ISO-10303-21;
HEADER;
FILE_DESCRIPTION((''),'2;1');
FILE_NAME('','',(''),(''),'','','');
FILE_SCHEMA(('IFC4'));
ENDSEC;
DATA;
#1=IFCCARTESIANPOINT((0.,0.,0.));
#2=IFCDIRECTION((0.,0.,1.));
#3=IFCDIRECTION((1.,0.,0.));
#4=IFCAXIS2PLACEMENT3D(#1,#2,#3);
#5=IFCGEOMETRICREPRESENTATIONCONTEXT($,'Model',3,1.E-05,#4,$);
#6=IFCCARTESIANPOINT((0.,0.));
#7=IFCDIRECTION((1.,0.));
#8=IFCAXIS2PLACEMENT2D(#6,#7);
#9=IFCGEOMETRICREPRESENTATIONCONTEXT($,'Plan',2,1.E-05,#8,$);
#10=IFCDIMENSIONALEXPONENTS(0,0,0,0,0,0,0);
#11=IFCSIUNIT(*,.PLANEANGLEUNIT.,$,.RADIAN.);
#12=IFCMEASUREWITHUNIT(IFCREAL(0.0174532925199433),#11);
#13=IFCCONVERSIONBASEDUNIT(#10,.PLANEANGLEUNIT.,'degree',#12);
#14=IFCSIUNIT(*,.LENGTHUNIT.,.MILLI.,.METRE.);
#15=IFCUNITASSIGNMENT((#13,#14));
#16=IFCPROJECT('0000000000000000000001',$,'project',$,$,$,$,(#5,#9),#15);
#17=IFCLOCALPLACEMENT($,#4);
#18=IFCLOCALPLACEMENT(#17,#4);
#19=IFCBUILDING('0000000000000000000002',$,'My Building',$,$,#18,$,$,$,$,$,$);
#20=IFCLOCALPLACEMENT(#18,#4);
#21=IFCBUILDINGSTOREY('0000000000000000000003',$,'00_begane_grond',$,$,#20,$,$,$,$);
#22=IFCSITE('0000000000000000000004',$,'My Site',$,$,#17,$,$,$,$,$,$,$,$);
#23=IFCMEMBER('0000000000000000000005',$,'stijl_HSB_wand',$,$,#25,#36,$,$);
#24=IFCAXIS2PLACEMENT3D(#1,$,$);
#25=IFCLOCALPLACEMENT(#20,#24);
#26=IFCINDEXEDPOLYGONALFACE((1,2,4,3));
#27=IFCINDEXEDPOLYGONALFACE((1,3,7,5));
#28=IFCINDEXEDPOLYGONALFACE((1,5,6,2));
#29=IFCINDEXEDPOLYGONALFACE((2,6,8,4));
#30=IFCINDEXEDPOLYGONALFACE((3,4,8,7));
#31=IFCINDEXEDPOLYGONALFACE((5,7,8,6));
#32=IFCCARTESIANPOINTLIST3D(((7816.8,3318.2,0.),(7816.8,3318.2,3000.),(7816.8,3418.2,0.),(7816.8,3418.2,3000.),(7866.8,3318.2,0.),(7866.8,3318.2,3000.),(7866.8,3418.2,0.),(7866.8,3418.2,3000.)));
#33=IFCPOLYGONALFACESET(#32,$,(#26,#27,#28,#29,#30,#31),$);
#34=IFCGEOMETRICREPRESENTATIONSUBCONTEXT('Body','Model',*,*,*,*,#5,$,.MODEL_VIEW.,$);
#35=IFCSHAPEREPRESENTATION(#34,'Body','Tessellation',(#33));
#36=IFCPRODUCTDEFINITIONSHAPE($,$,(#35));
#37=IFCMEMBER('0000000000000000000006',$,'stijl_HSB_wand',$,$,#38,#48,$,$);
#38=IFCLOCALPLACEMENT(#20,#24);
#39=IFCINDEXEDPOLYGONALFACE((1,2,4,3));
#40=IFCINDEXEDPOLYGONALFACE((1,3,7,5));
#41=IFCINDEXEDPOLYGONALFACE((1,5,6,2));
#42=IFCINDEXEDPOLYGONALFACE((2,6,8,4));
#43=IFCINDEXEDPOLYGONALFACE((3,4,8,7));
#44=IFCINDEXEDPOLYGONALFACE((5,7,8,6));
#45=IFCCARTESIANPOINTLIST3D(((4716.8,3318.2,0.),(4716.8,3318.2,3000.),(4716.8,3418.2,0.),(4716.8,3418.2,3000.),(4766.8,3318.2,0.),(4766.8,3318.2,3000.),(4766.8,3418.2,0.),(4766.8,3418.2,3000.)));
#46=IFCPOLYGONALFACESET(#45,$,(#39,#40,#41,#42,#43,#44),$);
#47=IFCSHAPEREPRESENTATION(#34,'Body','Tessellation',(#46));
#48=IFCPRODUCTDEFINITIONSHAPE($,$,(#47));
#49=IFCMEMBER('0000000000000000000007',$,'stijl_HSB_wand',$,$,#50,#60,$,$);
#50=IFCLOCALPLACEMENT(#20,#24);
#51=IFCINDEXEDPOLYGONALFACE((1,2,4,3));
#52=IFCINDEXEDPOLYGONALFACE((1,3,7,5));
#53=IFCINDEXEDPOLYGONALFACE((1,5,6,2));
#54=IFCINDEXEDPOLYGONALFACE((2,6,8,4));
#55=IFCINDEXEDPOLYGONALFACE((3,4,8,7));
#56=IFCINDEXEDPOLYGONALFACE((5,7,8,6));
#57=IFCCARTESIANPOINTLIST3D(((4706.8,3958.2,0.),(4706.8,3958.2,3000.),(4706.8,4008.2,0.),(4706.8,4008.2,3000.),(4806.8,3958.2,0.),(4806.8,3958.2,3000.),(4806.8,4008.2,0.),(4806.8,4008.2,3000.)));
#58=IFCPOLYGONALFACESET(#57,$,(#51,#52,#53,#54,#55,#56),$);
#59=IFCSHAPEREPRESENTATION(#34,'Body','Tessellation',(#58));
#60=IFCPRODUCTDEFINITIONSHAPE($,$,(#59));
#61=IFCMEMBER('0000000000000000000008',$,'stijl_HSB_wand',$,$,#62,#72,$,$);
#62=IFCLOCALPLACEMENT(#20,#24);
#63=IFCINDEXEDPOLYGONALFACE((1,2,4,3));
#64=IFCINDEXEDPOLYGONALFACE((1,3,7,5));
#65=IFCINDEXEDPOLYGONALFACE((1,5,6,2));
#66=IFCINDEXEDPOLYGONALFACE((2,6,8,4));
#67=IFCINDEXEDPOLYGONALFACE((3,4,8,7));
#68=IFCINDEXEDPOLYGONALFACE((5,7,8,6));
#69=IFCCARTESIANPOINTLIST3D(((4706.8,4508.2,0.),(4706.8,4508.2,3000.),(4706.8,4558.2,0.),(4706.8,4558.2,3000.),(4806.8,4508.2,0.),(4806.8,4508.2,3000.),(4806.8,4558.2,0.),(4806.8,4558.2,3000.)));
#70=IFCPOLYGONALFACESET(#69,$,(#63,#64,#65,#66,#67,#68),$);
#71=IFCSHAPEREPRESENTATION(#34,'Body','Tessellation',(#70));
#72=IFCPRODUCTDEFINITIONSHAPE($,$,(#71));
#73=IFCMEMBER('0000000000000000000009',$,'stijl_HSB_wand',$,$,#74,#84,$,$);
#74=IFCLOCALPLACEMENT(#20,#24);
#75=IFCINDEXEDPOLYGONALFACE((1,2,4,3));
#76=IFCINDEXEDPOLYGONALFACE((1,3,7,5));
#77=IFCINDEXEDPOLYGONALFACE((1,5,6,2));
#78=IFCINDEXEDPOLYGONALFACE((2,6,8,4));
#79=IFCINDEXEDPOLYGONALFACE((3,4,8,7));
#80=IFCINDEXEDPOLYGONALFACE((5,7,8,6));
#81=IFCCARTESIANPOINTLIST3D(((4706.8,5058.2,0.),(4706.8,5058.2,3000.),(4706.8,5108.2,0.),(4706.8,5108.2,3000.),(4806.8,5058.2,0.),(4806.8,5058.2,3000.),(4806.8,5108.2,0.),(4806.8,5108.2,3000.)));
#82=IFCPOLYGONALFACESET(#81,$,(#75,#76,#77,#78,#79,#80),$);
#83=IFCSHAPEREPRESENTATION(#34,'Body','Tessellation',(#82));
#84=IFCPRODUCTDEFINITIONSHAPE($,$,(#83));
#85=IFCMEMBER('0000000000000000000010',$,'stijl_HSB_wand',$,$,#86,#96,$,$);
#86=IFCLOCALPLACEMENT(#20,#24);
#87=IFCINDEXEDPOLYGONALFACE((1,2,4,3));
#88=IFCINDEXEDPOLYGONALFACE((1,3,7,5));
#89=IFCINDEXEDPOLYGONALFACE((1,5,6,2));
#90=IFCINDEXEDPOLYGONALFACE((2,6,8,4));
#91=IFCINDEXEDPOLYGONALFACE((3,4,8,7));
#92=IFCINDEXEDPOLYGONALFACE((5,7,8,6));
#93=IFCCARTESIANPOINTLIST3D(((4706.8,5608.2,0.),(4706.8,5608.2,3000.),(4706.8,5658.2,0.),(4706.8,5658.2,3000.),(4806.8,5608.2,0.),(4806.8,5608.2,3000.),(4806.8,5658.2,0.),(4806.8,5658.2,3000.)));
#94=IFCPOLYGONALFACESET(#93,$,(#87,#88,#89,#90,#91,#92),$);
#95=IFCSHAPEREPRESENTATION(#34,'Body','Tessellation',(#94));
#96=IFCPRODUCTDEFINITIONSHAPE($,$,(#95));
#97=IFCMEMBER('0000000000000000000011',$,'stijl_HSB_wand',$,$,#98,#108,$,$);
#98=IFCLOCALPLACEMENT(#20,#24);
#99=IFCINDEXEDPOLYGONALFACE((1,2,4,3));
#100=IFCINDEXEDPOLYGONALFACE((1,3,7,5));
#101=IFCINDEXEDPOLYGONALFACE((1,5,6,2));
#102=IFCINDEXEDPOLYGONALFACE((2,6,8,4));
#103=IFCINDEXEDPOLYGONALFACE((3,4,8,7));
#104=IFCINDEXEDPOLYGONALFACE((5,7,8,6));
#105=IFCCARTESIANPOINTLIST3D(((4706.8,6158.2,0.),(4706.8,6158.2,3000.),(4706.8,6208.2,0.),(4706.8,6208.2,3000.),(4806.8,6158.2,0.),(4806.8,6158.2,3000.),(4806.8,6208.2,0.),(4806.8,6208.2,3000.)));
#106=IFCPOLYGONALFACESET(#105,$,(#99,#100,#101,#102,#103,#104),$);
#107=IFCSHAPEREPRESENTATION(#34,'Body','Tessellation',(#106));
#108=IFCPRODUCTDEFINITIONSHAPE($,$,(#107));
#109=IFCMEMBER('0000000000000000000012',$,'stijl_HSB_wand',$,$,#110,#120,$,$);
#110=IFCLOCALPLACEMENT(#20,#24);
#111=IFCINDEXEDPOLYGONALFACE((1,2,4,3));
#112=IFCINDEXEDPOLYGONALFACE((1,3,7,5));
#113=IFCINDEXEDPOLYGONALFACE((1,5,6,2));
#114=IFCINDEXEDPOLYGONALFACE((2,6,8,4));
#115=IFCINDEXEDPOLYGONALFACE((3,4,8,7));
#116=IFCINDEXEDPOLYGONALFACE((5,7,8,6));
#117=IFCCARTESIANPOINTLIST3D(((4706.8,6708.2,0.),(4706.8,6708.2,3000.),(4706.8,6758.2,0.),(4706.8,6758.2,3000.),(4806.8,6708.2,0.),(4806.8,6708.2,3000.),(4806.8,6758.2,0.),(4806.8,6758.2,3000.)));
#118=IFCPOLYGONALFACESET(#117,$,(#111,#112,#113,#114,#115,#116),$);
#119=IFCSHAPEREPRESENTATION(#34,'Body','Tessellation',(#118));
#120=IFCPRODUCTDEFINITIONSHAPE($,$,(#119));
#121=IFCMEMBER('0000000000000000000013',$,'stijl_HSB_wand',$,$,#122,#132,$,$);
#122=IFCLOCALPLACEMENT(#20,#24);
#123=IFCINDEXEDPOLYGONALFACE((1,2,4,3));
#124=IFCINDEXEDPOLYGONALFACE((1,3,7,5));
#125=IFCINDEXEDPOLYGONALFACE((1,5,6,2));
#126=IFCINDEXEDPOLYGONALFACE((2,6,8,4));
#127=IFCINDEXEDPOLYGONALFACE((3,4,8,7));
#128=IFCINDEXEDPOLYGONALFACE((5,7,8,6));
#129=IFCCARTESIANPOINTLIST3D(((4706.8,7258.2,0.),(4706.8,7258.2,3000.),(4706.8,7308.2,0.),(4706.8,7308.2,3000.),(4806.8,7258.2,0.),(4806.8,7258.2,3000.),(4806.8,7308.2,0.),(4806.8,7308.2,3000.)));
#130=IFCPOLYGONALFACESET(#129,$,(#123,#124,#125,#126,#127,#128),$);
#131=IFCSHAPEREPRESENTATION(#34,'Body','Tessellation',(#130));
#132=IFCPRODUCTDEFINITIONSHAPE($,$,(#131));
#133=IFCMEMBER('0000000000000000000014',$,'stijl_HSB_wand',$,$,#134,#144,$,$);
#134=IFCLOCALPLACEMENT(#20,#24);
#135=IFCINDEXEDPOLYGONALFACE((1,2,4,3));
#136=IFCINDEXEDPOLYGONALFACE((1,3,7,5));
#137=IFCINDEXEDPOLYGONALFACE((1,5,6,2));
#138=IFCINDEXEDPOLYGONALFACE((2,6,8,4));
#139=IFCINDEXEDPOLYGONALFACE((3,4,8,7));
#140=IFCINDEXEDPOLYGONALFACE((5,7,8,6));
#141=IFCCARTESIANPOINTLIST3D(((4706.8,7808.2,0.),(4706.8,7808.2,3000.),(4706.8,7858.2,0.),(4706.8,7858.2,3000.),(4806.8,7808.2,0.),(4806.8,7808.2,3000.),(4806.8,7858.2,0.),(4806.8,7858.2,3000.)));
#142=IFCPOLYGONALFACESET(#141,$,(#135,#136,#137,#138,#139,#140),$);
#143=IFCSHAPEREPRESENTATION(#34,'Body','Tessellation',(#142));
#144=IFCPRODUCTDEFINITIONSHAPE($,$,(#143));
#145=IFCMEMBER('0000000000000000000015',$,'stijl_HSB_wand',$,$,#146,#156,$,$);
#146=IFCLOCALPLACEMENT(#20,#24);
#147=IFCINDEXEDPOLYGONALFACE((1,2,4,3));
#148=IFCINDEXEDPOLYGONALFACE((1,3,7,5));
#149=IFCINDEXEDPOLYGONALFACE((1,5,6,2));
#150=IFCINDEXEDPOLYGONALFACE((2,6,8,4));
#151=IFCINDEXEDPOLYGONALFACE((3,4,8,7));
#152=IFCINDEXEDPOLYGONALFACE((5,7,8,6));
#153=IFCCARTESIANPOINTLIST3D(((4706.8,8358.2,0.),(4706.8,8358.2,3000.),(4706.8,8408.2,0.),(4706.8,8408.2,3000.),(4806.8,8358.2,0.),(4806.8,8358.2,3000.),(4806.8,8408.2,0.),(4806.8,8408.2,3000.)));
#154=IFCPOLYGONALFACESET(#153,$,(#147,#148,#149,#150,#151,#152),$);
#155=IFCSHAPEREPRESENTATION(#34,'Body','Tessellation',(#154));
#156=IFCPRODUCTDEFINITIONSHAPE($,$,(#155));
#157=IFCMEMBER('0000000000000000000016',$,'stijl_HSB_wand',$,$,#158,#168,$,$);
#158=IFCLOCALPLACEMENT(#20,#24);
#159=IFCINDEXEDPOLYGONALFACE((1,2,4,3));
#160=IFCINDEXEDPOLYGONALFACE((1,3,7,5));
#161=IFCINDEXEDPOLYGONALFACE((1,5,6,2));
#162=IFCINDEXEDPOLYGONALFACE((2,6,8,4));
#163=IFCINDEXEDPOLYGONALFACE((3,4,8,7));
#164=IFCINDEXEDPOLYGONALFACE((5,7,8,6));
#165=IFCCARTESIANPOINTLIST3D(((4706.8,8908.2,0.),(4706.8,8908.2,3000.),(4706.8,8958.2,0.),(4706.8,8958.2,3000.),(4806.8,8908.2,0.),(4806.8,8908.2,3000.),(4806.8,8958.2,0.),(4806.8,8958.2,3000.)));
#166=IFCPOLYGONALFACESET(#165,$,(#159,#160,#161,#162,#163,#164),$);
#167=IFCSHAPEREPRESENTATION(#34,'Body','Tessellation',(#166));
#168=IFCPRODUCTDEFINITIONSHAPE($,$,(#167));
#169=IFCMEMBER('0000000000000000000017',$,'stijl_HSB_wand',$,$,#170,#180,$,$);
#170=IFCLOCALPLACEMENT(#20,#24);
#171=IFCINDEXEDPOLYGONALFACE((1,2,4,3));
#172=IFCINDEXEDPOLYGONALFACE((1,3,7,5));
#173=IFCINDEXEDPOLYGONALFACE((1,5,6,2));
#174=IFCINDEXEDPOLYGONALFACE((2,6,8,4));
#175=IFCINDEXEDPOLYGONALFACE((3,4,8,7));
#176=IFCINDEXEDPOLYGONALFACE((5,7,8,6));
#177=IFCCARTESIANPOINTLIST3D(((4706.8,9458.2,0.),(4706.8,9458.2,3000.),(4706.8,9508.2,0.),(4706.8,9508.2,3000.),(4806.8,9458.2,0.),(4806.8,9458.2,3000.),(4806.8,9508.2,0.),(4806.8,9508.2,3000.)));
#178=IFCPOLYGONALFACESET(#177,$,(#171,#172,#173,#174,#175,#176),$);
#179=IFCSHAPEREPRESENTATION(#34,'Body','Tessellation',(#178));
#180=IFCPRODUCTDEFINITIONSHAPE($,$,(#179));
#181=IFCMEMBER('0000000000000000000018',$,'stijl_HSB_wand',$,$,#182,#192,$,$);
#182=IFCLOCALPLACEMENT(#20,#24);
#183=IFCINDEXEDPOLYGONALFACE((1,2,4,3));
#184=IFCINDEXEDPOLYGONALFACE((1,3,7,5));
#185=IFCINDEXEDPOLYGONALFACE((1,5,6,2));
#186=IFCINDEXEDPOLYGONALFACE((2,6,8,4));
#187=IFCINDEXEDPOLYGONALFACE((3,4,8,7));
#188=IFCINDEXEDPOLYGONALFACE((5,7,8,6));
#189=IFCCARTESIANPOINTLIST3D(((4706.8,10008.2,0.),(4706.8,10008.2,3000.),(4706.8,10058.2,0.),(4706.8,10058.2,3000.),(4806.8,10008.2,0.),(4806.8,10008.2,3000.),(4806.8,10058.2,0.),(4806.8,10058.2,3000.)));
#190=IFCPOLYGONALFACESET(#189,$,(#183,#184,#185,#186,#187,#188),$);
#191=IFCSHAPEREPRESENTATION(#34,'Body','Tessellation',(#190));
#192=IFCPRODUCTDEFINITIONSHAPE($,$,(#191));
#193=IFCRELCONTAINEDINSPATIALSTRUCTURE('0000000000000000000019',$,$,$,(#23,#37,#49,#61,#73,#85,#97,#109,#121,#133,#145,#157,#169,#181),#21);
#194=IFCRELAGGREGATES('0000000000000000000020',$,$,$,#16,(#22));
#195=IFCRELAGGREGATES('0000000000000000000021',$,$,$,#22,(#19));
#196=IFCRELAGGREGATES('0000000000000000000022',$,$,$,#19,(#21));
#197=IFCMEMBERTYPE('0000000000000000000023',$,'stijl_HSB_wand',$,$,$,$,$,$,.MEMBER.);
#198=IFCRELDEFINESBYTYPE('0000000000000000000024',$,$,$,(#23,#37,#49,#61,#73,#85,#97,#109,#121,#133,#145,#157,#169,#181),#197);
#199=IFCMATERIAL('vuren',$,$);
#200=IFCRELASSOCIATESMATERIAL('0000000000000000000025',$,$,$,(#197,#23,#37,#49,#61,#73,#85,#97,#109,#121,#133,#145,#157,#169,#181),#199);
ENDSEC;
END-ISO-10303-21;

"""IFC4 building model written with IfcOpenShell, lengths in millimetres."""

from ifc_helpers import new_model, entity, si_unit, converted_unit, frame, origin_with_axes, origin_2d_with_axis, place, context, subcontext, project, spatial, rectangle, extrude, material, material_profile, profile_set, profile_usage, type_object, element, save


model = new_model("IFC4")

# Units and contexts
model_context = context("Model", 3, precision=1e-05, world=origin_with_axes())
plan_context = context("Plan", 2, precision=1e-05, world=origin_2d_with_axis())
body_context = subcontext(model_context, "Body", "Model", "MODEL_VIEW")
ifc_project = project(units=[converted_unit("PLANEANGLEUNIT", "degree", entity("IfcReal", 0.0174532925199433), si_unit("PLANEANGLEUNIT", "RADIAN"), dimensions=[0, 0, 0, 0, 0, 0, 0]), si_unit("LENGTHUNIT", "METRE", prefix="MILLI")], contexts=[model_context, plan_context])

# Site, building, storey
site_placement = place(None, origin_with_axes())
site = spatial("IfcSite", under=ifc_project, at=site_placement, Name="My Site")
building_placement = place(site_placement, origin_with_axes())
building = spatial("IfcBuilding", under=site, at=building_placement, Name="My Building")
storey_placement = place(building_placement, origin_with_axes())
storey = spatial("IfcBuildingStorey", under=building, at=storey_placement, Name="00_begane_grond")

# Members
ifc_material_1 = material(Name="vuren")
ifc_material_profile_1 = material_profile(ifc_material_1, rectangle(XDim=100.0, YDim=50.0))
ifc_material_profile_2 = material_profile(ifc_material_1, rectangle(XDim=100.0, YDim=50.0))
ifc_profile_set = profile_set([ifc_material_profile_1, ifc_material_profile_2])
ifc_profile_usage_1 = profile_usage(ifc_profile_set, cardinal=1)
member_type = type_object("IfcMemberType", Name="stijl_HSB_wand", PredefinedType="MEMBER", material=ifc_profile_set)
member_1_placement = place(storey_placement, frame((7866.8, 3418.2, 0.0), z_axis=(0.0, 0.0, 1.0), x_axis=(0.0, 1.0, 0.0)))
element("IfcMember", 1, at=member_1_placement, inside=storey, type_object=member_type, material=ifc_profile_usage_1, Name="stijl_HSB_wand", context=body_context, shape_type="SweptSolid", body=[
    extrude(rectangle(XDim=100.0, YDim=50.0), frame((-50.0, 25.0, 0.0), z_axis=(0.0, 0.0, 1.0), x_axis=(1.0, 0.0, 0.0)), (0.0, 0.0, 1.0), 3000.0),
])
ifc_profile_usage_2 = profile_usage(ifc_profile_set, cardinal=1)
member_2_placement = place(storey_placement, frame((4766.8, 3418.2, 0.0), z_axis=(0.0, 0.0, 1.0), x_axis=(0.0, 1.0, 0.0)))
element("IfcMember", 2, at=member_2_placement, inside=storey, type_object=member_type, material=ifc_profile_usage_2, Name="stijl_HSB_wand", context=body_context, shape_type="SweptSolid", body=[
    extrude(rectangle(XDim=100.0, YDim=50.0), frame((-50.0, 25.0, 0.0), z_axis=(0.0, 0.0, 1.0), x_axis=(1.0, 0.0, 0.0)), (0.0, 0.0, 1.0), 3000.0),
])
ifc_profile_usage_3 = profile_usage(ifc_profile_set, cardinal=1)
member_3_placement = place(storey_placement, frame((4806.8, 3958.2, 0.0), z_axis=(0.0, 0.0, 1.0), x_axis=(1.0, 0.0, 0.0)))
element("IfcMember", 3, at=member_3_placement, inside=storey, type_object=member_type, material=ifc_profile_usage_3, Name="stijl_HSB_wand", context=body_context, shape_type="SweptSolid", body=[
    extrude(rectangle(XDim=100.0, YDim=50.0), frame((-50.0, 25.0, 0.0), z_axis=(0.0, 0.0, 1.0), x_axis=(1.0, 0.0, 0.0)), (0.0, 0.0, 1.0), 3000.0),
])
ifc_profile_usage_4 = profile_usage(ifc_profile_set, cardinal=1)
member_4_placement = place(storey_placement, frame((4806.8, 4508.2, 0.0), z_axis=(0.0, 0.0, 1.0), x_axis=(1.0, 0.0, 0.0)))
element("IfcMember", 4, at=member_4_placement, inside=storey, type_object=member_type, material=ifc_profile_usage_4, Name="stijl_HSB_wand", context=body_context, shape_type="SweptSolid", body=[
    extrude(rectangle(XDim=100.0, YDim=50.0), frame((-50.0, 25.0, 0.0), z_axis=(0.0, 0.0, 1.0), x_axis=(1.0, 0.0, 0.0)), (0.0, 0.0, 1.0), 3000.0),
])
ifc_profile_usage_5 = profile_usage(ifc_profile_set, cardinal=1)
member_5_placement = place(storey_placement, frame((4806.8, 5058.2, 0.0), z_axis=(0.0, 0.0, 1.0), x_axis=(1.0, 0.0, 0.0)))
element("IfcMember", 5, at=member_5_placement, inside=storey, type_object=member_type, material=ifc_profile_usage_5, Name="stijl_HSB_wand", context=body_context, shape_type="SweptSolid", body=[
    extrude(rectangle(XDim=100.0, YDim=50.0), frame((-50.0, 25.0, 0.0), z_axis=(0.0, 0.0, 1.0), x_axis=(1.0, 0.0, 0.0)), (0.0, 0.0, 1.0), 3000.0),
])
ifc_profile_usage_6 = profile_usage(ifc_profile_set, cardinal=1)
member_6_placement = place(storey_placement, frame((4806.8, 5608.2, 0.0), z_axis=(0.0, 0.0, 1.0), x_axis=(1.0, 0.0, 0.0)))
element("IfcMember", 6, at=member_6_placement, inside=storey, type_object=member_type, material=ifc_profile_usage_6, Name="stijl_HSB_wand", context=body_context, shape_type="SweptSolid", body=[
    extrude(rectangle(XDim=100.0, YDim=50.0), frame((-50.0, 25.0, 0.0), z_axis=(0.0, 0.0, 1.0), x_axis=(1.0, 0.0, 0.0)), (0.0, 0.0, 1.0), 3000.0),
])
ifc_profile_usage_7 = profile_usage(ifc_profile_set, cardinal=1)
member_7_placement = place(storey_placement, frame((4806.8, 6158.2, 0.0), z_axis=(0.0, 0.0, 1.0), x_axis=(1.0, 0.0, 0.0)))
element("IfcMember", 7, at=member_7_placement, inside=storey, type_object=member_type, material=ifc_profile_usage_7, Name="stijl_HSB_wand", context=body_context, shape_type="SweptSolid", body=[
    extrude(rectangle(XDim=100.0, YDim=50.0), frame((-50.0, 25.0, 0.0), z_axis=(0.0, 0.0, 1.0), x_axis=(1.0, 0.0, 0.0)), (0.0, 0.0, 1.0), 3000.0),
])
ifc_profile_usage_8 = profile_usage(ifc_profile_set, cardinal=1)
member_8_placement = place(storey_placement, frame((4806.8, 6708.2, 0.0), z_axis=(0.0, 0.0, 1.0), x_axis=(1.0, 0.0, 0.0)))
element("IfcMember", 8, at=member_8_placement, inside=storey, type_object=member_type, material=ifc_profile_usage_8, Name="stijl_HSB_wand", context=body_context, shape_type="SweptSolid", body=[
    extrude(rectangle(XDim=100.0, YDim=50.0), frame((-50.0, 25.0, 0.0), z_axis=(0.0, 0.0, 1.0), x_axis=(1.0, 0.0, 0.0)), (0.0, 0.0, 1.0), 3000.0),
])
ifc_profile_usage_9 = profile_usage(ifc_profile_set, cardinal=1)
member_9_placement = place(storey_placement, frame((4806.8, 7258.2, 0.0), z_axis=(0.0, 0.0, 1.0), x_axis=(1.0, 0.0, 0.0)))
element("IfcMember", 9, at=member_9_placement, inside=storey, type_object=member_type, material=ifc_profile_usage_9, Name="stijl_HSB_wand", context=body_context, shape_type="SweptSolid", body=[
    extrude(rectangle(XDim=100.0, YDim=50.0), frame((-50.0, 25.0, 0.0), z_axis=(0.0, 0.0, 1.0), x_axis=(1.0, 0.0, 0.0)), (0.0, 0.0, 1.0), 3000.0),
])
ifc_profile_usage_10 = profile_usage(ifc_profile_set, cardinal=1)
member_10_placement = place(storey_placement, frame((4806.8, 7808.2, 0.0), z_axis=(0.0, 0.0, 1.0), x_axis=(1.0, 0.0, 0.0)))
element("IfcMember", 10, at=member_10_placement, inside=storey, type_object=member_type, material=ifc_profile_usage_10, Name="stijl_HSB_wand", context=body_context, shape_type="SweptSolid", body=[
    extrude(rectangle(XDim=100.0, YDim=50.0), frame((-50.0, 25.0, 0.0), z_axis=(0.0, 0.0, 1.0), x_axis=(1.0, 0.0, 0.0)), (0.0, 0.0, 1.0), 3000.0),
])
ifc_profile_usage_11 = profile_usage(ifc_profile_set, cardinal=1)
member_11_placement = place(storey_placement, frame((4806.8, 8358.2, 0.0), z_axis=(0.0, 0.0, 1.0), x_axis=(1.0, 0.0, 0.0)))
element("IfcMember", 11, at=member_11_placement, inside=storey, type_object=member_type, material=ifc_profile_usage_11, Name="stijl_HSB_wand", context=body_context, shape_type="SweptSolid", body=[
    extrude(rectangle(XDim=100.0, YDim=50.0), frame((-50.0, 25.0, 0.0), z_axis=(0.0, 0.0, 1.0), x_axis=(1.0, 0.0, 0.0)), (0.0, 0.0, 1.0), 3000.0),
])
ifc_profile_usage_12 = profile_usage(ifc_profile_set, cardinal=1)
member_12_placement = place(storey_placement, frame((4806.8, 8908.2, 0.0), z_axis=(0.0, 0.0, 1.0), x_axis=(1.0, 0.0, 0.0)))
element("IfcMember", 12, at=member_12_placement, inside=storey, type_object=member_type, material=ifc_profile_usage_12, Name="stijl_HSB_wand", context=body_context, shape_type="SweptSolid", body=[
    extrude(rectangle(XDim=100.0, YDim=50.0), frame((-50.0, 25.0, 0.0), z_axis=(0.0, 0.0, 1.0), x_axis=(1.0, 0.0, 0.0)), (0.0, 0.0, 1.0), 3000.0),
])
ifc_profile_usage_13 = profile_usage(ifc_profile_set, cardinal=1)
member_13_placement = place(storey_placement, frame((4806.8, 9458.2, 0.0), z_axis=(0.0, 0.0, 1.0), x_axis=(1.0, 0.0, 0.0)))
element("IfcMember", 13, at=member_13_placement, inside=storey, type_object=member_type, material=ifc_profile_usage_13, Name="stijl_HSB_wand", context=body_context, shape_type="SweptSolid", body=[
    extrude(rectangle(XDim=100.0, YDim=50.0), frame((-50.0, 25.0, 0.0), z_axis=(0.0, 0.0, 1.0), x_axis=(1.0, 0.0, 0.0)), (0.0, 0.0, 1.0), 3000.0),
])
ifc_profile_usage_14 = profile_usage(ifc_profile_set, cardinal=1)
member_14_placement = place(storey_placement, frame((4806.8, 10008.2, 0.0), z_axis=(0.0, 0.0, 1.0), x_axis=(1.0, 0.0, 0.0)))
element("IfcMember", 14, at=member_14_placement, inside=storey, type_object=member_type, material=ifc_profile_usage_14, Name="stijl_HSB_wand", context=body_context, shape_type="SweptSolid", body=[
    extrude(rectangle(XDim=100.0, YDim=50.0), frame((-50.0, 25.0, 0.0), z_axis=(0.0, 0.0, 1.0), x_axis=(1.0, 0.0, 0.0)), (0.0, 0.0, 1.0), 3000.0),
])

save(model, "model.ifc")
